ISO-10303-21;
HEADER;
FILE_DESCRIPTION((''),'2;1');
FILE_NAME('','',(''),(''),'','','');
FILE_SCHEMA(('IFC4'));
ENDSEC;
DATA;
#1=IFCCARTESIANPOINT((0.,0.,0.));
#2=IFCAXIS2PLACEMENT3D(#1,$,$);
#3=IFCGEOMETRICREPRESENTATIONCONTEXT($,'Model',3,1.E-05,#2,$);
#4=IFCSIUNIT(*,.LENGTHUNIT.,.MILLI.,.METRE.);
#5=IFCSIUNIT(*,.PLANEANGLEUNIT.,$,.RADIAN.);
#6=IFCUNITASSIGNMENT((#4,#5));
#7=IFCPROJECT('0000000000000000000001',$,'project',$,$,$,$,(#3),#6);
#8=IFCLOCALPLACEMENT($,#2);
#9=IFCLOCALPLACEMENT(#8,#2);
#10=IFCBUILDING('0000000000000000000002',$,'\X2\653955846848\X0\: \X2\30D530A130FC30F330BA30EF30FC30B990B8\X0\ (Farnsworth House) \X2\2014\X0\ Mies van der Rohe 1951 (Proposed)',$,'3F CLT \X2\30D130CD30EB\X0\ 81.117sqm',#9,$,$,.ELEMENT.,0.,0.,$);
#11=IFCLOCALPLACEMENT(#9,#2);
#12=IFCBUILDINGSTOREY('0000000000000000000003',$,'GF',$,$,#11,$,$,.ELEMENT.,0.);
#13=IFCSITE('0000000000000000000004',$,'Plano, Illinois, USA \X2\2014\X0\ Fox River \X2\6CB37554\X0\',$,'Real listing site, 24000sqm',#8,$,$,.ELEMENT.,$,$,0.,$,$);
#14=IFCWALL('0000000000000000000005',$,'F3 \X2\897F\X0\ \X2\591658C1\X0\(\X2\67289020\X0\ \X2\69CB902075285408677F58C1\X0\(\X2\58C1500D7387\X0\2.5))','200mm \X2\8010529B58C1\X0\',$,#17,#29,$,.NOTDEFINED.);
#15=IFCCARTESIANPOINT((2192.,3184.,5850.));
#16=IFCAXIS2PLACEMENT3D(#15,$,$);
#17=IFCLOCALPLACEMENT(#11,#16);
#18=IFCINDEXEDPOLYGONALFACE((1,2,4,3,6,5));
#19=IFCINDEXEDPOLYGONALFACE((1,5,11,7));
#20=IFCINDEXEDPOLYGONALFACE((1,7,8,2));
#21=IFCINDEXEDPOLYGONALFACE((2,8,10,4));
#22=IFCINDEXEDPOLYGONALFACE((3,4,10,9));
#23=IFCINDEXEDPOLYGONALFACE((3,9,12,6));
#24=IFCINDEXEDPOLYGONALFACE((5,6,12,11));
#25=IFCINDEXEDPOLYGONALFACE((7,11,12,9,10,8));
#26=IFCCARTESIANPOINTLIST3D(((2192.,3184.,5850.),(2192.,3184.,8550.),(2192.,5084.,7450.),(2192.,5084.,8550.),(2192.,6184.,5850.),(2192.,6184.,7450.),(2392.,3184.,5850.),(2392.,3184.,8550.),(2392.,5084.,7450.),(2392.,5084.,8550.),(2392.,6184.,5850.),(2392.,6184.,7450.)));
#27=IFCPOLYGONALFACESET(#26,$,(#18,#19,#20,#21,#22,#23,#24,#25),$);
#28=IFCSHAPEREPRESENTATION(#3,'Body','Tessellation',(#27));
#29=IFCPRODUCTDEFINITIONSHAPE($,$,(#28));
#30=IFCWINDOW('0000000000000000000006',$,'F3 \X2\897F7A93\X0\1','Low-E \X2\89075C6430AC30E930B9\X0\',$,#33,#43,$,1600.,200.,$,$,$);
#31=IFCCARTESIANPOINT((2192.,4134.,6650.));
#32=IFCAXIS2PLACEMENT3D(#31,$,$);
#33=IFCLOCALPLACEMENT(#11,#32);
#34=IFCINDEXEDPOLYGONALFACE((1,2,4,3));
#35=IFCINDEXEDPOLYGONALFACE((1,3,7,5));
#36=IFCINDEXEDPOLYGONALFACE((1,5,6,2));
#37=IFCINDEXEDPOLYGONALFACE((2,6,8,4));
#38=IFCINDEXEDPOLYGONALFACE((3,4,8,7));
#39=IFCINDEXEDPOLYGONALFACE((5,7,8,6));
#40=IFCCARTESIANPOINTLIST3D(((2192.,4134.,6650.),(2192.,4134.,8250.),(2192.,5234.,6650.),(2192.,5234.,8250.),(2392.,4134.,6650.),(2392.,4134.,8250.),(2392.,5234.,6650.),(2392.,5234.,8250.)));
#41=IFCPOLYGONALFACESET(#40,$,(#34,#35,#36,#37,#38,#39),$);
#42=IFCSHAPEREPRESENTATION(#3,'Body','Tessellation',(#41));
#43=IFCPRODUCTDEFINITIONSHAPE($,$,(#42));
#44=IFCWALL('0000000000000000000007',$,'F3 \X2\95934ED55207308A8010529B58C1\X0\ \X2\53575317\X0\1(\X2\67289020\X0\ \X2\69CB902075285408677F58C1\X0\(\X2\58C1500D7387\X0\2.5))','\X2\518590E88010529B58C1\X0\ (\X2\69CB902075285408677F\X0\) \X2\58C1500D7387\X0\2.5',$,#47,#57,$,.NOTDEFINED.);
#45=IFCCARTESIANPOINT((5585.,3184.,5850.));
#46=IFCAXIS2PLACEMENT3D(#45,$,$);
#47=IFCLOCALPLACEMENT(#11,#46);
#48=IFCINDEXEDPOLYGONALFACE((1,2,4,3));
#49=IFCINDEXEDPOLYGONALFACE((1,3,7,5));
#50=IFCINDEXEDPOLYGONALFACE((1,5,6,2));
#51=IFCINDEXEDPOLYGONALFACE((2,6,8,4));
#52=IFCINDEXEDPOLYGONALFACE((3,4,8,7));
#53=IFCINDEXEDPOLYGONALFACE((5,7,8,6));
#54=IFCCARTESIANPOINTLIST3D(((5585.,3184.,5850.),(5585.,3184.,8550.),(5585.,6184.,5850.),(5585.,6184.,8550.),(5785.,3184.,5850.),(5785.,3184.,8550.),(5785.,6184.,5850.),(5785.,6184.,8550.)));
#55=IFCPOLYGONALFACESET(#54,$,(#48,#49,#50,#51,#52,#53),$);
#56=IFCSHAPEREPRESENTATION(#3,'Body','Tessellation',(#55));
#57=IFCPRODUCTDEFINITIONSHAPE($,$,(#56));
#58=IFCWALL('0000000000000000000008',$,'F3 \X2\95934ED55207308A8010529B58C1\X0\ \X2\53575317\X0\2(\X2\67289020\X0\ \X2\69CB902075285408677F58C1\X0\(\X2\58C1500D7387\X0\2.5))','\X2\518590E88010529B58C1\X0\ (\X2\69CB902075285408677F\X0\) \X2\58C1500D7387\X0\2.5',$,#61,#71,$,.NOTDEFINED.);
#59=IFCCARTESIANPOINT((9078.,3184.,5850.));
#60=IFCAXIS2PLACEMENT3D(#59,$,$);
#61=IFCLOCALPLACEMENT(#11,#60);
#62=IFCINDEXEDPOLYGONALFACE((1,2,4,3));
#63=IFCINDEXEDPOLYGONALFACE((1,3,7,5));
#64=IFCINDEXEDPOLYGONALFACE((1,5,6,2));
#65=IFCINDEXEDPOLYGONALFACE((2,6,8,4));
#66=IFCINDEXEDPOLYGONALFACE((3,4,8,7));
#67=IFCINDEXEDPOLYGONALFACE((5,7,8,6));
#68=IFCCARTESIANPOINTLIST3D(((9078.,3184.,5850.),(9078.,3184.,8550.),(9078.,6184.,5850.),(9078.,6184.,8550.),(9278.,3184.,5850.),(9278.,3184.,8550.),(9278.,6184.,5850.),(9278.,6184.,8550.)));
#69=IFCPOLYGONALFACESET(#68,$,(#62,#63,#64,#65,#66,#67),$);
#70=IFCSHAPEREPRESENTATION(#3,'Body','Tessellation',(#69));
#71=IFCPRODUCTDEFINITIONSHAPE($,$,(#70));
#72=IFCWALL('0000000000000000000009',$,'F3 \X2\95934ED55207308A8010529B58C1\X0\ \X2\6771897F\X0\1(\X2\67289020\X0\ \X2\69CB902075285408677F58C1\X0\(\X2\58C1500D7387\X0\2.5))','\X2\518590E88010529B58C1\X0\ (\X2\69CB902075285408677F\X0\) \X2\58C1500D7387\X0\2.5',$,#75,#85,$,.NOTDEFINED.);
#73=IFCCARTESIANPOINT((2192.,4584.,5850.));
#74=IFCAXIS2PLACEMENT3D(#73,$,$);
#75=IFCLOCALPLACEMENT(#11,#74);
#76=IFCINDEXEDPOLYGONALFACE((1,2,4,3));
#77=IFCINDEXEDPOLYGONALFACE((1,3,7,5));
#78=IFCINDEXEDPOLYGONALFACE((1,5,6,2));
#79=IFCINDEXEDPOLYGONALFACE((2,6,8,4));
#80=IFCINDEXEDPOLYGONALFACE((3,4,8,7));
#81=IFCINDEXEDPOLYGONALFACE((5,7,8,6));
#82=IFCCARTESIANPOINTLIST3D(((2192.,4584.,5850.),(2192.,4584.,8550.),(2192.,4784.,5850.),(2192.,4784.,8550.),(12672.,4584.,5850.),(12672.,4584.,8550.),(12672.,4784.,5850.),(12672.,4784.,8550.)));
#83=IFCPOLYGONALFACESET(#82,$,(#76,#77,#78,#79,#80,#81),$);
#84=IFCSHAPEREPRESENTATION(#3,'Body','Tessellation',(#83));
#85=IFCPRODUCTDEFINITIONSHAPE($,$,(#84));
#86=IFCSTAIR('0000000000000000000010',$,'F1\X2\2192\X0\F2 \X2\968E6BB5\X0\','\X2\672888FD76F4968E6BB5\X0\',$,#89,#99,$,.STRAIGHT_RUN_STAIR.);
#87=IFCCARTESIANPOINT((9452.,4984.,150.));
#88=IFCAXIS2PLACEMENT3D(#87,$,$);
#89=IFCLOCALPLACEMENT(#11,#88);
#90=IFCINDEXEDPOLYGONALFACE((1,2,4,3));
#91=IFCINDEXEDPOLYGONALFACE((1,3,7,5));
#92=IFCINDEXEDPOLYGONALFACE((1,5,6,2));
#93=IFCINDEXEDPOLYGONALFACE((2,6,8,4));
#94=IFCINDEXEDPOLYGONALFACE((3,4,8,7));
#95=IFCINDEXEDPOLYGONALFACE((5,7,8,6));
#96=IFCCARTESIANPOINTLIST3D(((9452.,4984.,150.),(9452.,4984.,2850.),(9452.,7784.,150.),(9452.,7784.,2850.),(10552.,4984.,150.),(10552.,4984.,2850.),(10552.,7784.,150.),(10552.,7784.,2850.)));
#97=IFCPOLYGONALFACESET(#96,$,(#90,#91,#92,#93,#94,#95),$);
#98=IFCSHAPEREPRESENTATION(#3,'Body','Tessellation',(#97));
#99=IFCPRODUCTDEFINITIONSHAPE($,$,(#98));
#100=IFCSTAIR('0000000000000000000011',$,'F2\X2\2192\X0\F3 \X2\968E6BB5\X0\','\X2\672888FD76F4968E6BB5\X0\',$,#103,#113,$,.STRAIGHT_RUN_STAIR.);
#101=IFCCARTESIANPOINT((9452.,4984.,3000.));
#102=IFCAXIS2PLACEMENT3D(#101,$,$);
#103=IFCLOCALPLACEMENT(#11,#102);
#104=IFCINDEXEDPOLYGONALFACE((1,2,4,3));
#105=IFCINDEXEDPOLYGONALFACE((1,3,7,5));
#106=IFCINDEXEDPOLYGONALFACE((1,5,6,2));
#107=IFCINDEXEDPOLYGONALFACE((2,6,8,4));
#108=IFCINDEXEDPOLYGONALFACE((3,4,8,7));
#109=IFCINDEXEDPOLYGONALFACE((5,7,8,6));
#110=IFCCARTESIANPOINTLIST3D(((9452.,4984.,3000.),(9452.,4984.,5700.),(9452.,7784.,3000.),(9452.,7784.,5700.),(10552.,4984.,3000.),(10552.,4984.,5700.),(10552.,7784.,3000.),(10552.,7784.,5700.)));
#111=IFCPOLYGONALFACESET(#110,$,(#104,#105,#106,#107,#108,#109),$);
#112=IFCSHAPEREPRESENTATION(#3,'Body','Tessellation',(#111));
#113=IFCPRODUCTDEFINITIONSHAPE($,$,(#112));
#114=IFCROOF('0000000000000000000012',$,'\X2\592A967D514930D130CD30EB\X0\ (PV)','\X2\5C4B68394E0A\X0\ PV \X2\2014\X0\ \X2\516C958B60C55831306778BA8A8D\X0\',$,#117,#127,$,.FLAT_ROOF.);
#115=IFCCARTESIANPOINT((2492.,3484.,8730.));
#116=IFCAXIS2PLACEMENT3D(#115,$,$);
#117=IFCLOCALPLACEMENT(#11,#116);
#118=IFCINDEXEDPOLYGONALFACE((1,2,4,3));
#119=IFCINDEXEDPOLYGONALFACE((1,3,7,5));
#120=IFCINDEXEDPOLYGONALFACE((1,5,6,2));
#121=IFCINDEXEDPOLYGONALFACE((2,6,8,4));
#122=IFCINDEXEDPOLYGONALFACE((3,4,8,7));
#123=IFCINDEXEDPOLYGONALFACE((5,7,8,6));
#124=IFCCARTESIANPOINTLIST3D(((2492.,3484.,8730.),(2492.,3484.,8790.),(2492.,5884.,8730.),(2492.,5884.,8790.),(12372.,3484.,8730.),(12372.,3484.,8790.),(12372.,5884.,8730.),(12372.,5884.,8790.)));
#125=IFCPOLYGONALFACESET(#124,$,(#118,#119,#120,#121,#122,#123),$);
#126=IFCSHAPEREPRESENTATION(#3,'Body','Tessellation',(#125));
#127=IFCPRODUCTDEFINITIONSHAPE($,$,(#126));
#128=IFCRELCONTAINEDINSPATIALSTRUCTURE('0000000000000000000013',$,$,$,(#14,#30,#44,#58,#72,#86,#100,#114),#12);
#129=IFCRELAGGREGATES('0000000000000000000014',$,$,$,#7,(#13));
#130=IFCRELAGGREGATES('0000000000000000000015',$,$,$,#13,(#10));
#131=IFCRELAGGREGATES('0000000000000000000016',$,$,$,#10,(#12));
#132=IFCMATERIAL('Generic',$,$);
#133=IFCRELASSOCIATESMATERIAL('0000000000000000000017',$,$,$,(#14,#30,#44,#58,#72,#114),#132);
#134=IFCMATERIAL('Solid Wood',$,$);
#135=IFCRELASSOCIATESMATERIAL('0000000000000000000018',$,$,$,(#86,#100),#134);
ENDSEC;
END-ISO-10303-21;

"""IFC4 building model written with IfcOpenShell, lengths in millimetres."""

from ifc_helpers import new_model, si_unit, frame, frame_2d, origin, place, context, project, spatial, rectangle, extrude, material, element, fill, save


model = new_model("IFC4")

# Units and contexts
model_context = context("Model", 3, precision=1e-05, world=origin())
ifc_project = project(units=[si_unit("LENGTHUNIT", "METRE", prefix="MILLI"), si_unit("PLANEANGLEUNIT", "RADIAN")], contexts=[model_context])

# Site, building, storey
site_placement = place(None, origin())
site = spatial("IfcSite", under=ifc_project, at=site_placement, Name="Plano, Illinois, USA — Fox River 河畔", ObjectType="Real listing site, 24000sqm", CompositionType="ELEMENT", RefElevation=0.0)
building_placement = place(site_placement, origin())
building = spatial("IfcBuilding", under=site, at=building_placement, Name="改善案: ファーンズワース邸 (Farnsworth House) — Mies van der Rohe 1951 (Proposed)", ObjectType="3F CLT パネル 81.117sqm", CompositionType="ELEMENT", ElevationOfRefHeight=0.0, ElevationOfTerrain=0.0)
storey_placement = place(building_placement, origin())
storey = spatial("IfcBuildingStorey", under=building, at=storey_placement, Name="GF", CompositionType="ELEMENT", Elevation=0.0)

# Shared definitions
ifc_material_1 = material(Name="Generic")

# Wall, opening, window
wall_1_placement = place(storey_placement, frame((2192.0, 3184.0, 5850.0)))
wall_1 = element("IfcWall", 1, at=wall_1_placement, inside=storey, material=ifc_material_1, Name="F3 西 外壁(木造 構造用合板壁(壁倍率2.5))", Description="200mm 耐力壁", PredefinedType="NOTDEFINED", context=model_context, shape_type="SweptSolid", body=[
    extrude(rectangle(XDim=200.0, YDim=3000.0, at=frame_2d((100.0, 1500.0))), frame((2192.0, 3184.0, 5850.0)), (0.0, 0.0, 1.0), 2700.0),
])
opening_1_placement = place(storey_placement, frame((2192.0, 4134.0, 6650.0)))
opening_1 = element("IfcOpeningElement", 2, at=opening_1_placement, cuts=wall_1, PredefinedType="NOTDEFINED", context=model_context, shape_type="SweptSolid", body=[
    extrude(rectangle(XDim=200.0, YDim=1100.0, at=frame_2d((100.0, 550.0))), frame((2192.0, 4134.0, 6650.0)), (0.0, 0.0, 1.0), 1600.0),
])
window_1_placement = place(storey_placement, frame((2192.0, 4134.0, 6650.0)))
window_1 = element("IfcWindow", 3, at=window_1_placement, inside=storey, material=ifc_material_1, Name="F3 西窓1", Description="Low-E 複層ガラス", OverallHeight=1600.0, OverallWidth=200.0, context=model_context, shape_type="SweptSolid", body=[
    extrude(rectangle(XDim=200.0, YDim=1100.0, at=frame_2d((100.0, 550.0))), frame((2192.0, 4134.0, 6650.0)), (0.0, 0.0, 1.0), 1600.0),
])
fill(opening_1, window_1)

# Walls
wall_2_placement = place(storey_placement, frame((5585.0, 3184.0, 5850.0)))
element("IfcWall", 4, at=wall_2_placement, inside=storey, material=ifc_material_1, Name="F3 間仕切り耐力壁 南北1(木造 構造用合板壁(壁倍率2.5))", Description="内部耐力壁 (構造用合板) 壁倍率2.5", PredefinedType="NOTDEFINED", context=model_context, shape_type="SweptSolid", body=[
    extrude(rectangle(XDim=200.0, YDim=3000.0, at=frame_2d((100.0, 1500.0))), frame((5585.0, 3184.0, 5850.0)), (0.0, 0.0, 1.0), 2700.0),
])
wall_3_placement = place(storey_placement, frame((9078.0, 3184.0, 5850.0)))
element("IfcWall", 5, at=wall_3_placement, inside=storey, material=ifc_material_1, Name="F3 間仕切り耐力壁 南北2(木造 構造用合板壁(壁倍率2.5))", Description="内部耐力壁 (構造用合板) 壁倍率2.5", PredefinedType="NOTDEFINED", context=model_context, shape_type="SweptSolid", body=[
    extrude(rectangle(XDim=200.0, YDim=3000.0, at=frame_2d((100.0, 1500.0))), frame((9078.0, 3184.0, 5850.0)), (0.0, 0.0, 1.0), 2700.0),
])
wall_4_placement = place(storey_placement, frame((2192.0, 4584.0, 5850.0)))
element("IfcWall", 6, at=wall_4_placement, inside=storey, material=ifc_material_1, Name="F3 間仕切り耐力壁 東西1(木造 構造用合板壁(壁倍率2.5))", Description="内部耐力壁 (構造用合板) 壁倍率2.5", PredefinedType="NOTDEFINED", context=model_context, shape_type="SweptSolid", body=[
    extrude(rectangle(XDim=10480.0, YDim=200.0, at=frame_2d((5240.0, 100.0))), frame((2192.0, 4584.0, 5850.0)), (0.0, 0.0, 1.0), 2700.0),
])

# Stairs
ifc_material_2 = material(Name="Solid Wood")
stair_1_placement = place(storey_placement, frame((9452.0, 4984.0, 150.0)))
element("IfcStair", 7, at=stair_1_placement, inside=storey, material=ifc_material_2, Name="F1→F2 階段", Description="木製直階段", PredefinedType="STRAIGHT_RUN_STAIR", context=model_context, shape_type="SweptSolid", body=[
    extrude(rectangle(XDim=1100.0, YDim=2800.0, at=frame_2d((550.0, 1400.0))), frame((9452.0, 4984.0, 150.0)), (0.0, 0.0, 1.0), 2700.0),
])
stair_2_placement = place(storey_placement, frame((9452.0, 4984.0, 3000.0)))
element("IfcStair", 8, at=stair_2_placement, inside=storey, material=ifc_material_2, Name="F2→F3 階段", Description="木製直階段", PredefinedType="STRAIGHT_RUN_STAIR", context=model_context, shape_type="SweptSolid", body=[
    extrude(rectangle(XDim=1100.0, YDim=2800.0, at=frame_2d((550.0, 1400.0))), frame((9452.0, 4984.0, 3000.0)), (0.0, 0.0, 1.0), 2700.0),
])

# Roof
roof_placement = place(storey_placement, frame((2492.0, 3484.0, 8730.0)))
element("IfcRoof", 9, at=roof_placement, inside=storey, material=ifc_material_1, Name="太陽光パネル (PV)", Description="屋根上 PV — 公開情報で確認", PredefinedType="FLAT_ROOF", context=model_context, shape_type="SweptSolid", body=[
    extrude(rectangle(XDim=9880.0, YDim=2400.0, at=frame_2d((4940.0, 1200.0))), frame((2492.0, 3484.0, 8730.0)), (0.0, 0.0, 1.0), 60.0),
])

save(model, "model.ifc")
